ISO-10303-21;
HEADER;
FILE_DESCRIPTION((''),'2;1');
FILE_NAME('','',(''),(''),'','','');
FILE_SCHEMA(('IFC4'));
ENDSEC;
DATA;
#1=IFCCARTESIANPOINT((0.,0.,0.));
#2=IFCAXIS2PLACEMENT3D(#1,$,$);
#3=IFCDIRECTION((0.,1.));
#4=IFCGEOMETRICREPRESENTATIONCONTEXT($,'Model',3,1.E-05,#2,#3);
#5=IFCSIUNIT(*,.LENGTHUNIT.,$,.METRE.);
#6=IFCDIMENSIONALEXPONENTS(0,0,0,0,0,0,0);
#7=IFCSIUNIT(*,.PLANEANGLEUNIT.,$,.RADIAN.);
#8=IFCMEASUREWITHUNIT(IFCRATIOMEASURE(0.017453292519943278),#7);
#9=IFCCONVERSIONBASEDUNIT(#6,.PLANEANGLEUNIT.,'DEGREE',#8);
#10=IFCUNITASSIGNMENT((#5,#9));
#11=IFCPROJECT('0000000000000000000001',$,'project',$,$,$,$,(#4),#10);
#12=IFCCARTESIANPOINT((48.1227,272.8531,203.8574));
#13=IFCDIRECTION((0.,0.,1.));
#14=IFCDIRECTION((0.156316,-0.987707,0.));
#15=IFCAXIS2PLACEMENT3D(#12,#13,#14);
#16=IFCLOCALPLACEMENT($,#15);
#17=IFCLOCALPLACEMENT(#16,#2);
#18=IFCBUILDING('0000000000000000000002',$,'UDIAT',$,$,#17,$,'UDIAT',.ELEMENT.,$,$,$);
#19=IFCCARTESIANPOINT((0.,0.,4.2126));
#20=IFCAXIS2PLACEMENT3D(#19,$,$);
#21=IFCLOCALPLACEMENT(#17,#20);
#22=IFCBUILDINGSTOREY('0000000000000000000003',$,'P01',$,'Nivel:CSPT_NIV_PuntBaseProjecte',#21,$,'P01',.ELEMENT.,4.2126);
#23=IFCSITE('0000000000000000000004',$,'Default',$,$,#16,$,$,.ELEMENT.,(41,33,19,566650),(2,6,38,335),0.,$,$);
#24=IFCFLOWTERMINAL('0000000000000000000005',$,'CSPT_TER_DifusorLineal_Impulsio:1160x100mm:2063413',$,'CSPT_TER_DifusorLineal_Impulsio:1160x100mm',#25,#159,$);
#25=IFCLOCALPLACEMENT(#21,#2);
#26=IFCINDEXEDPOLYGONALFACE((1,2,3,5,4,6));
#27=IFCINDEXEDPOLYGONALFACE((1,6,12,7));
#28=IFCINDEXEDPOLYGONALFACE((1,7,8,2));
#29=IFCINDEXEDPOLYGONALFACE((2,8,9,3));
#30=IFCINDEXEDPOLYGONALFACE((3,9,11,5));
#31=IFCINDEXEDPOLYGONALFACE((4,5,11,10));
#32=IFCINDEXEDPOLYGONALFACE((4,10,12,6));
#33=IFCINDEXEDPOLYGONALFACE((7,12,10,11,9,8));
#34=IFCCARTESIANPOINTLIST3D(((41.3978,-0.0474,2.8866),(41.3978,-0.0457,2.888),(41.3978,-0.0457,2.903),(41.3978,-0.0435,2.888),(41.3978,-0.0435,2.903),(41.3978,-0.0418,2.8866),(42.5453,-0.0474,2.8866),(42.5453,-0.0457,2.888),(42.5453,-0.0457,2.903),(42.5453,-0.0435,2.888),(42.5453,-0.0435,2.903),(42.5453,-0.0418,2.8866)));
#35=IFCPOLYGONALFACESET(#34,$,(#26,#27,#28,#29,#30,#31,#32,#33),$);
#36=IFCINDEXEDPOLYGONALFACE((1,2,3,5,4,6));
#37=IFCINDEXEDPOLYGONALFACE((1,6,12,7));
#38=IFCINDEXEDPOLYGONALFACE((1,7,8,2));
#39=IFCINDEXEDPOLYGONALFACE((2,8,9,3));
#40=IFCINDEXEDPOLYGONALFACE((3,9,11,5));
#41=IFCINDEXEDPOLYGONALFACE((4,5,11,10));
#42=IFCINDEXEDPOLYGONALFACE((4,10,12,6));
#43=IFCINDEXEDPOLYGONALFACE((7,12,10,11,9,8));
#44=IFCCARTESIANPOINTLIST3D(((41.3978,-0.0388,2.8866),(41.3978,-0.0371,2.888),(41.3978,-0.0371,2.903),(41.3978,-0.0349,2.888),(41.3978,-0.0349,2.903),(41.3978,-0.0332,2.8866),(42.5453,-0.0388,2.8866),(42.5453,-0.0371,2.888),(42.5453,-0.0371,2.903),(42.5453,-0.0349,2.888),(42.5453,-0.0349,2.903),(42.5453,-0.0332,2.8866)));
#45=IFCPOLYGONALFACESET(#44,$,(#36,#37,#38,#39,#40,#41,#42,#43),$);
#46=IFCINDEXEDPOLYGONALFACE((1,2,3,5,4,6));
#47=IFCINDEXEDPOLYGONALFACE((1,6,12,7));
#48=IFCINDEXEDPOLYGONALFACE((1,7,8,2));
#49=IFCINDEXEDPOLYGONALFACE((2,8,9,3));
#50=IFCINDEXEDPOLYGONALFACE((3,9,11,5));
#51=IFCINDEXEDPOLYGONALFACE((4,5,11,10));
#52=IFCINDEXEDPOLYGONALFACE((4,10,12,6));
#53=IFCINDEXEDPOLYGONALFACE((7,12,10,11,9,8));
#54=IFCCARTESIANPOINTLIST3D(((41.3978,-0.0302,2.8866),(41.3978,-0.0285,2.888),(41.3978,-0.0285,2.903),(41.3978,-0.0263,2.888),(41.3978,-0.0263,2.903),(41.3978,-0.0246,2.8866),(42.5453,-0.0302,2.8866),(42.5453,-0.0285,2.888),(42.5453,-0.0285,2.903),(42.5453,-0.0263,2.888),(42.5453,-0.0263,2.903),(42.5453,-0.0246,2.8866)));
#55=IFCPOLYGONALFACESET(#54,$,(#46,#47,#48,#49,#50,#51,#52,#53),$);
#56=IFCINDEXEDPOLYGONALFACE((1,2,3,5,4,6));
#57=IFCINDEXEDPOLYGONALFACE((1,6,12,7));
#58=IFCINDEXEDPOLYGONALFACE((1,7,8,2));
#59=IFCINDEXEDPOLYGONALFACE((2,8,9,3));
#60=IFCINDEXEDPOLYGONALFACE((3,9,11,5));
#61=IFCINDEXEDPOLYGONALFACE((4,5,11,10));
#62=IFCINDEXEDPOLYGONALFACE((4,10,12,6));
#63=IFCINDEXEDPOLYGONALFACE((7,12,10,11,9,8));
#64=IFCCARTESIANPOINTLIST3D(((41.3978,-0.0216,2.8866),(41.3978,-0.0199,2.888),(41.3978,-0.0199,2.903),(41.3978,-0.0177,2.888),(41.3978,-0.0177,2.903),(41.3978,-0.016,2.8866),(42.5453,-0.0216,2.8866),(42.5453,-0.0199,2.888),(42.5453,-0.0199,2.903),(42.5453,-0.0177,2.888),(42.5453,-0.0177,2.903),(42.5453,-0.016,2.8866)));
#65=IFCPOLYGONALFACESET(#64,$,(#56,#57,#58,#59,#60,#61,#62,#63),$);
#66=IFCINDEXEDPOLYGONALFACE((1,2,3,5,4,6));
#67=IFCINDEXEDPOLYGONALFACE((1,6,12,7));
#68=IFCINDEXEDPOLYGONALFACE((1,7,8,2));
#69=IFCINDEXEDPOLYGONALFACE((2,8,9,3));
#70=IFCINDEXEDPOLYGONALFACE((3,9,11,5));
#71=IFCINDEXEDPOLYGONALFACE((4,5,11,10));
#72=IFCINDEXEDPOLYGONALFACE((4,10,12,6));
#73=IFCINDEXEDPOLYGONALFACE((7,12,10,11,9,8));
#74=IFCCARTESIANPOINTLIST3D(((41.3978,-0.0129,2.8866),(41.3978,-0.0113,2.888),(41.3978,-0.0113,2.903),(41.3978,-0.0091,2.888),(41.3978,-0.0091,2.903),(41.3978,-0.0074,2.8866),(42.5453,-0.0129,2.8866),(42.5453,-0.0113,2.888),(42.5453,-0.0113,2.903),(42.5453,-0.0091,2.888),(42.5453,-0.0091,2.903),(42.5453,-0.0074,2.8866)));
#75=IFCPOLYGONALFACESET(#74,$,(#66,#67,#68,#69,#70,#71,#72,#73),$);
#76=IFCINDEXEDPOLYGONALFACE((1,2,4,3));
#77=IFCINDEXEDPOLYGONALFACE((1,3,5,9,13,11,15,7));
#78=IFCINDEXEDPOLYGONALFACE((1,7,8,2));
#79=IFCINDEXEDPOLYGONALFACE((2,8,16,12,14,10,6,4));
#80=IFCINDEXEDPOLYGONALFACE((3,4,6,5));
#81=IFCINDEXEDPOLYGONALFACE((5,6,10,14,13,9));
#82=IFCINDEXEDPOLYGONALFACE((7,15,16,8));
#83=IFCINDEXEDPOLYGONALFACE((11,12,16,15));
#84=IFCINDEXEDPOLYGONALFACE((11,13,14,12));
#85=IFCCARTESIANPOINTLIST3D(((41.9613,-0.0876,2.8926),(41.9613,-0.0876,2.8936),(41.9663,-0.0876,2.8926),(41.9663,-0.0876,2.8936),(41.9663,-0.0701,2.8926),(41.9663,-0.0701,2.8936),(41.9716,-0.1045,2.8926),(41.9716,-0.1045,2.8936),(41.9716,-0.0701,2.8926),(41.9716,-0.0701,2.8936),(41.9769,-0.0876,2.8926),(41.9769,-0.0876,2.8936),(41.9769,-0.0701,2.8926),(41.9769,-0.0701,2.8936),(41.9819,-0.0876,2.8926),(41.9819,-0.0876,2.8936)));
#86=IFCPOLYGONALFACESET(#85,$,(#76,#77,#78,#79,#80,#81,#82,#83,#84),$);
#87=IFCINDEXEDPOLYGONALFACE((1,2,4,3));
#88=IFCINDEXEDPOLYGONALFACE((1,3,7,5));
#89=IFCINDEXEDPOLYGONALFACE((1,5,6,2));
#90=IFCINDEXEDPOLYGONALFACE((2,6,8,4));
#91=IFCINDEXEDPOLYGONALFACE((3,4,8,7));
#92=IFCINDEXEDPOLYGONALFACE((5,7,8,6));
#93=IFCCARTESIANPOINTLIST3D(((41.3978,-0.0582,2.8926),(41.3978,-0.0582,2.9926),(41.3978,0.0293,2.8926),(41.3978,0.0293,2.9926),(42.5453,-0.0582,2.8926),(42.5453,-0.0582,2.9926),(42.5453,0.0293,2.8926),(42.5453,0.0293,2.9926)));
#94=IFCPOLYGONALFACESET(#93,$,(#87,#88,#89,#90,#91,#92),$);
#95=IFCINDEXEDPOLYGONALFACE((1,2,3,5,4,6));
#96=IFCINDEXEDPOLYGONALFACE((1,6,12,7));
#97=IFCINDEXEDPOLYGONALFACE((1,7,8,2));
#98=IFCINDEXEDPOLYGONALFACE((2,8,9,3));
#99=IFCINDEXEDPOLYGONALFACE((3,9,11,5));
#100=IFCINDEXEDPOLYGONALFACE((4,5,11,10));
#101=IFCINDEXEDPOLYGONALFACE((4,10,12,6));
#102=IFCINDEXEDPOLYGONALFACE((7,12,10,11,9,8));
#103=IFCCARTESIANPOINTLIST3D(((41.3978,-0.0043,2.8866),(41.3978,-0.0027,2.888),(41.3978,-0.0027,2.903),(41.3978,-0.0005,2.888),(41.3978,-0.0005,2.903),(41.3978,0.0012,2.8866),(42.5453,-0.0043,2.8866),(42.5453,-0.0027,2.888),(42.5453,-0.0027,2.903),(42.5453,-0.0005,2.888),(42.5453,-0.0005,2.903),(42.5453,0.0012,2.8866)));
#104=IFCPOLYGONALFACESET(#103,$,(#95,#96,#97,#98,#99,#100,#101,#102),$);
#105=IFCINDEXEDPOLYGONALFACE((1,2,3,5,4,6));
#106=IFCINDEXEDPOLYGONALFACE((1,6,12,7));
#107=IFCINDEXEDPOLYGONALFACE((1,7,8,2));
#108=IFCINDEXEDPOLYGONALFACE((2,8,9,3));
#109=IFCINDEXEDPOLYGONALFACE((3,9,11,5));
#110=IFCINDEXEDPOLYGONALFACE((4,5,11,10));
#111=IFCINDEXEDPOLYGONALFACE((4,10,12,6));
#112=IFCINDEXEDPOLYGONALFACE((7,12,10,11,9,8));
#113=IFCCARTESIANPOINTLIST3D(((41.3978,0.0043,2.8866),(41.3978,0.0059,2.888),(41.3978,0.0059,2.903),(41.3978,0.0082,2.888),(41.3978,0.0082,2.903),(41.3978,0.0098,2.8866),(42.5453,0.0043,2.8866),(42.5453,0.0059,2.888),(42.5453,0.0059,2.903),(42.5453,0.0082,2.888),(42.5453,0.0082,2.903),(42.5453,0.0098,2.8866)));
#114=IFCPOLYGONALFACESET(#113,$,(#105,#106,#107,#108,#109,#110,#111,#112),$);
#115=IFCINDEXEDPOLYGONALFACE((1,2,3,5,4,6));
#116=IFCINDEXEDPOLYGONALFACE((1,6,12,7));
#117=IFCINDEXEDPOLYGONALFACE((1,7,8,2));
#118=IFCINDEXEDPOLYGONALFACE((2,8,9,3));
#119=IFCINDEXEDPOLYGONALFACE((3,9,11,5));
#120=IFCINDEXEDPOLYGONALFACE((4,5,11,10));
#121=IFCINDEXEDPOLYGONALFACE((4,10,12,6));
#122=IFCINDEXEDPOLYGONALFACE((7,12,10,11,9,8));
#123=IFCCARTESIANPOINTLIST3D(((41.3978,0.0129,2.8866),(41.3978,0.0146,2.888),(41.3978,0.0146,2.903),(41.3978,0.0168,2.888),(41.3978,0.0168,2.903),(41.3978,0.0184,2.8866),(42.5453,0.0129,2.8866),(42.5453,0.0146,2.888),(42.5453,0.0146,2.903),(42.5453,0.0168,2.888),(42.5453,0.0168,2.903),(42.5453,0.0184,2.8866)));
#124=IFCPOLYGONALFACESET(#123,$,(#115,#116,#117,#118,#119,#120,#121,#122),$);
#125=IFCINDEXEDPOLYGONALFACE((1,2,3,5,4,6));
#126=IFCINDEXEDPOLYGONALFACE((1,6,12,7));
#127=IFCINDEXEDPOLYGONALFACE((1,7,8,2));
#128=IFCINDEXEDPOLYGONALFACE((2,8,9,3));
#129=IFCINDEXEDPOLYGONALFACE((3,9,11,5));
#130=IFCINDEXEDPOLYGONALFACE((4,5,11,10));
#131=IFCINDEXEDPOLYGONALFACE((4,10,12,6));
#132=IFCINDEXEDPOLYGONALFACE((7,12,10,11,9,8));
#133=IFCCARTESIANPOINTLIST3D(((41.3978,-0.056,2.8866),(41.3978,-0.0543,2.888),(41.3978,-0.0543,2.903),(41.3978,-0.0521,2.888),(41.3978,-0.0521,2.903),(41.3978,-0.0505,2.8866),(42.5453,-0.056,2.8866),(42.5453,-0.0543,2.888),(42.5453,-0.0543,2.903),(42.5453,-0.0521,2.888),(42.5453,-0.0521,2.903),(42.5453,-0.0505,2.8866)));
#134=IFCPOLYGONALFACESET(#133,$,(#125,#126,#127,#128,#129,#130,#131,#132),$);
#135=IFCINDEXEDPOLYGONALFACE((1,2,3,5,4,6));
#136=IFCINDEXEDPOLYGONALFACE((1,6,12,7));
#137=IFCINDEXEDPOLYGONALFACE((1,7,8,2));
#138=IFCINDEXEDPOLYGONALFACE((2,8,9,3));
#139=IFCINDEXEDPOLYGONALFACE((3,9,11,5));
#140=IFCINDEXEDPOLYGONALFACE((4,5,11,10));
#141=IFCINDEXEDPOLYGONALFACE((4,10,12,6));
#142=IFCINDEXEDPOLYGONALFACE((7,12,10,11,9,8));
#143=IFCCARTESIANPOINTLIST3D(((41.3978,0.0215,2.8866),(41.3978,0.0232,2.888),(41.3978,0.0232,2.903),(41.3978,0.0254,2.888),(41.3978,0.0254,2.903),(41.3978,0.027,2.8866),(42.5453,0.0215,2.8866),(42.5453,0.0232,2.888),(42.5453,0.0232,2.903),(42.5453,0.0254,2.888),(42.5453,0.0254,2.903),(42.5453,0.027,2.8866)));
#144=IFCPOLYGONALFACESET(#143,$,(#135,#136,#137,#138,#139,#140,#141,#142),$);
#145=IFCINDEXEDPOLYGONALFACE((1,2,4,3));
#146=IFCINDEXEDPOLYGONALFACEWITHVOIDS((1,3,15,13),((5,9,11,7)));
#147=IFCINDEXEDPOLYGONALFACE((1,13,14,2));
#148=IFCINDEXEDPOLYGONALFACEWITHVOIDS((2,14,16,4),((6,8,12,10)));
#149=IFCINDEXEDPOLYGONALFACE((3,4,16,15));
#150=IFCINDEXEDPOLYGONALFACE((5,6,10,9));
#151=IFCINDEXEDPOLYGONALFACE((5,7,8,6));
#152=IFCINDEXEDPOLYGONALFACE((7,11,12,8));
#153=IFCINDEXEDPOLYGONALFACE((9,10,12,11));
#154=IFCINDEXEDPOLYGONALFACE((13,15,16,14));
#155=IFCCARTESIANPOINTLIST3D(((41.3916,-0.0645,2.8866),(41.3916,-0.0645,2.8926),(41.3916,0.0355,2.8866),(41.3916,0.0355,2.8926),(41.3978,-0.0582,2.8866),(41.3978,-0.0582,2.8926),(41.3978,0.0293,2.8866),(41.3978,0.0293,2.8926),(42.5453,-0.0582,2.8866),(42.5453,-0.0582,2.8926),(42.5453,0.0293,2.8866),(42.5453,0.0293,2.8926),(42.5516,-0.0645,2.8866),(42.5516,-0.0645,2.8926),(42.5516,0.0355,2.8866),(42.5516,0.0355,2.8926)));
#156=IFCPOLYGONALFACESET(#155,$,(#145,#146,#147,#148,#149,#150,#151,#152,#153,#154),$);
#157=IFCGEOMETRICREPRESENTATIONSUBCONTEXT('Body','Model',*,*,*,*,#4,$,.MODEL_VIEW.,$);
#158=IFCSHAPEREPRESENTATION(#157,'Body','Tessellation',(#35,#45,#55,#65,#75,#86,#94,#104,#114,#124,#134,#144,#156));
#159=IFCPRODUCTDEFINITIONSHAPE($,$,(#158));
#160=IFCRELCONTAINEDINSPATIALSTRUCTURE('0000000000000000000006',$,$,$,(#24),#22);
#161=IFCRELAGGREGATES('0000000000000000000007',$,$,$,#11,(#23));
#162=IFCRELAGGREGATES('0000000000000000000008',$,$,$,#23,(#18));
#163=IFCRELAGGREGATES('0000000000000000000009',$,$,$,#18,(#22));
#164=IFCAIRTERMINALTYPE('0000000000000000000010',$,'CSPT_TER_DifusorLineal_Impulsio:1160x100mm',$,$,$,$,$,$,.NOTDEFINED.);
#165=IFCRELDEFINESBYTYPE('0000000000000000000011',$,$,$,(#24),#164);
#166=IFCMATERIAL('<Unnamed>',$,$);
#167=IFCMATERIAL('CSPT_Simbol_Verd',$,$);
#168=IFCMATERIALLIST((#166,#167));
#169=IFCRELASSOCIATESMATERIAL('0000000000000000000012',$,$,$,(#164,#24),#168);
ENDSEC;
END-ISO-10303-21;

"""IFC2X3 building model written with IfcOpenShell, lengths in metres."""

from ifc_helpers import new_model, entity, si_unit, converted_unit, direction, frame, origin, origin_2d_with_axis, place, context, subcontext, project, spatial, polyline, rectangle, outline, extrude, source, transform, mapped, material, material_list, type_object, type_shapes, element, save


model = new_model("IFC2X3")

# Units and contexts
model_context = context("Model", 3, precision=1e-05, world=origin(), true_north=direction((0.0, 1.0)))
body_context = subcontext(model_context, "Body", "Model", "MODEL_VIEW")
ifc_project = project(units=[si_unit("LENGTHUNIT", "METRE"), converted_unit("PLANEANGLEUNIT", "DEGREE", entity("IfcRatioMeasure", 0.017453292519943278), si_unit("PLANEANGLEUNIT", "RADIAN"), dimensions=[0, 0, 0, 0, 0, 0, 0])], contexts=[model_context])

# Site, building, storey
site_placement = place(None, frame((48.1227, 272.8531, 203.8574), z_axis=(0.0, 0.0, 1.0), x_axis=(0.156316, -0.987707, 0.0)))
site = spatial("IfcSite", under=ifc_project, at=site_placement, Name="Default", CompositionType="ELEMENT", RefLatitude=(41, 33, 19, 566650), RefLongitude=(2, 6, 38, 335), RefElevation=0.0)
building_placement = place(site_placement, origin())
building = spatial("IfcBuilding", under=site, at=building_placement, Name="UDIAT", LongName="UDIAT", CompositionType="ELEMENT")
storey_placement = place(building_placement, frame((0.0, 0.0, 4.2126)))
storey = spatial("IfcBuildingStorey", under=building, at=storey_placement, Name="P01", ObjectType="Nivel:CSPT_NIV_PuntBaseProjecte", LongName="P01", CompositionType="ELEMENT", Elevation=4.2126)

# Shared definitions
ifc_material_1 = material(Name="<Unnamed>")

# Flow terminal
ifc_material_2 = material(Name="CSPT_Simbol_Verd")
ifc_material_list = material_list([ifc_material_1, ifc_material_2])
air_terminal_type = type_object("IfcAirTerminalType", Name="CSPT_TER_DifusorLineal_Impulsio:1160x100mm", PredefinedType="NOTDEFINED", material=ifc_material_list)
shared_shape_1 = source(origin(), body_context, "Body", "SweptSolid", [
    extrude(outline(polyline([(0.0037, 0.0028), (0.0059, 0.0028), (0.0016, 0.0063), (0.002, 0.0042), (-0.0074, -0.0074), (-0.0057, -0.0088), (0.0037, 0.0028)])), frame((-0.5737, 0.0301, -0.0001), z_axis=(1.0, 0.0, 0.0), x_axis=(0.0, -0.776119, -0.630587)), (0.0, 0.0, 1.0), 1.1475),
    extrude(outline(polyline([(0.0037, 0.0028), (0.0059, 0.0028), (0.0016, 0.0063), (0.002, 0.0042), (-0.0074, -0.0074), (-0.0057, -0.0088), (0.0037, 0.0028)])), frame((-0.5737, 0.0215, -0.0001), z_axis=(1.0, 0.0, 0.0), x_axis=(0.0, -0.776119, -0.630587)), (0.0, 0.0, 1.0), 1.1475),
    extrude(outline(polyline([(0.0037, 0.0028), (0.0059, 0.0028), (0.0016, 0.0063), (0.002, 0.0042), (-0.0074, -0.0074), (-0.0057, -0.0088), (0.0037, 0.0028)])), frame((-0.5737, 0.0129, -0.0001), z_axis=(1.0, 0.0, 0.0), x_axis=(0.0, -0.776119, -0.630587)), (0.0, 0.0, 1.0), 1.1475),
    extrude(outline(polyline([(0.0037, 0.0028), (0.0059, 0.0028), (0.0016, 0.0063), (0.002, 0.0042), (-0.0074, -0.0074), (-0.0057, -0.0088), (0.0037, 0.0028)])), frame((-0.5737, 0.0043, -0.0001), z_axis=(1.0, 0.0, 0.0), x_axis=(0.0, -0.776119, -0.630587)), (0.0, 0.0, 1.0), 1.1475),
    extrude(outline(polyline([(0.0037, 0.0028), (0.0059, 0.0028), (0.0016, 0.0063), (0.002, 0.0042), (-0.0074, -0.0074), (-0.0057, -0.0088), (0.0037, 0.0028)])), frame((-0.5737, -0.0043, -0.0001), z_axis=(1.0, 0.0, 0.0), x_axis=(0.0, -0.776119, -0.630587)), (0.0, 0.0, 1.0), 1.1475),
    extrude(outline(polyline([(0.0, -0.013), (0.0053, -0.013), (0.0053, 0.0045), (0.0103, 0.0045), (0.0, 0.0213), (-0.0103, 0.0045), (-0.0053, 0.0045), (-0.0053, -0.013), (0.0, -0.013)])), frame((0.0, 0.0687, 0.0)), (0.0, 0.0, 1.0), 0.001),
    extrude(rectangle(XDim=1.1475, YDim=0.0875, at=origin_2d_with_axis()), frame((0.0, 0.0, 0.0), z_axis=(0.0, 0.0, 1.0), x_axis=(-1.0, 0.0, 0.0)), (0.0, 0.0, 1.0), 0.1),
    extrude(outline(polyline([(0.0037, 0.0028), (0.0059, 0.0028), (0.0016, 0.0063), (0.002, 0.0042), (-0.0074, -0.0074), (-0.0057, -0.0088), (0.0037, 0.0028)])), frame((-0.5737, -0.0129, -0.0001), z_axis=(1.0, 0.0, 0.0), x_axis=(0.0, -0.776119, -0.630587)), (0.0, 0.0, 1.0), 1.1475),
    extrude(outline(polyline([(0.0037, 0.0028), (0.0059, 0.0028), (0.0016, 0.0063), (0.002, 0.0042), (-0.0074, -0.0074), (-0.0057, -0.0088), (0.0037, 0.0028)])), frame((-0.5737, -0.0215, -0.0001), z_axis=(1.0, 0.0, 0.0), x_axis=(0.0, -0.776119, -0.630587)), (0.0, 0.0, 1.0), 1.1475),
    extrude(outline(polyline([(0.0037, 0.0028), (0.0059, 0.0028), (0.0016, 0.0063), (0.002, 0.0042), (-0.0074, -0.0074), (-0.0057, -0.0088), (0.0037, 0.0028)])), frame((-0.5737, -0.0301, -0.0001), z_axis=(1.0, 0.0, 0.0), x_axis=(0.0, -0.776119, -0.630587)), (0.0, 0.0, 1.0), 1.1475),
    extrude(outline(polyline([(0.0037, 0.0028), (0.0059, 0.0028), (0.0016, 0.0063), (0.002, 0.0042), (-0.0074, -0.0074), (-0.0057, -0.0088), (0.0037, 0.0028)])), frame((-0.5737, 0.0388, -0.0001), z_axis=(1.0, 0.0, 0.0), x_axis=(0.0, -0.776119, -0.630587)), (0.0, 0.0, 1.0), 1.1475),
    extrude(outline(polyline([(0.0037, 0.0028), (0.0059, 0.0028), (0.0016, 0.0063), (0.002, 0.0042), (-0.0074, -0.0074), (-0.0057, -0.0088), (0.0037, 0.0028)])), frame((-0.5737, -0.0387, -0.0001), z_axis=(1.0, 0.0, 0.0), x_axis=(0.0, -0.776119, -0.630587)), (0.0, 0.0, 1.0), 1.1475),
    extrude(outline(polyline([(-0.58, -0.05), (0.58, -0.05), (0.58, 0.05), (-0.58, 0.05), (-0.58, -0.05)]), holes=[polyline([(-0.5738, -0.0438), (-0.5738, 0.0437), (0.5737, 0.0437), (0.5737, -0.0438), (-0.5738, -0.0438)])]), frame((0.0, 0.0, -0.006), z_axis=(0.0, 0.0, 1.0), x_axis=(-1.0, 0.0, 0.0)), (0.0, 0.0, 1.0), 0.006),
])
type_shapes(air_terminal_type, [shared_shape_1])
for number, where, z_axis, x_axis, name in (
    (1, (41.9716, -0.0145, 2.8926), (0.0, 0.0, 1.0), (-1.0, 0.0, 0.0), "CSPT_TER_DifusorLineal_Impulsio:1160x100mm:2063413"),
):
    element("IfcFlowTerminal", number, at=place(storey_placement, frame(where, z_axis=z_axis, x_axis=x_axis)), inside=storey, type_object=air_terminal_type, material=ifc_material_list, Name=name, ObjectType="CSPT_TER_DifusorLineal_Impulsio:1160x100mm", context=body_context, shape_type="MappedRepresentation", body=[
        mapped(shared_shape_1, transform((0.0, 0.0, 0.0), scale=1.0)),
    ])

save(model, "model.ifc")
